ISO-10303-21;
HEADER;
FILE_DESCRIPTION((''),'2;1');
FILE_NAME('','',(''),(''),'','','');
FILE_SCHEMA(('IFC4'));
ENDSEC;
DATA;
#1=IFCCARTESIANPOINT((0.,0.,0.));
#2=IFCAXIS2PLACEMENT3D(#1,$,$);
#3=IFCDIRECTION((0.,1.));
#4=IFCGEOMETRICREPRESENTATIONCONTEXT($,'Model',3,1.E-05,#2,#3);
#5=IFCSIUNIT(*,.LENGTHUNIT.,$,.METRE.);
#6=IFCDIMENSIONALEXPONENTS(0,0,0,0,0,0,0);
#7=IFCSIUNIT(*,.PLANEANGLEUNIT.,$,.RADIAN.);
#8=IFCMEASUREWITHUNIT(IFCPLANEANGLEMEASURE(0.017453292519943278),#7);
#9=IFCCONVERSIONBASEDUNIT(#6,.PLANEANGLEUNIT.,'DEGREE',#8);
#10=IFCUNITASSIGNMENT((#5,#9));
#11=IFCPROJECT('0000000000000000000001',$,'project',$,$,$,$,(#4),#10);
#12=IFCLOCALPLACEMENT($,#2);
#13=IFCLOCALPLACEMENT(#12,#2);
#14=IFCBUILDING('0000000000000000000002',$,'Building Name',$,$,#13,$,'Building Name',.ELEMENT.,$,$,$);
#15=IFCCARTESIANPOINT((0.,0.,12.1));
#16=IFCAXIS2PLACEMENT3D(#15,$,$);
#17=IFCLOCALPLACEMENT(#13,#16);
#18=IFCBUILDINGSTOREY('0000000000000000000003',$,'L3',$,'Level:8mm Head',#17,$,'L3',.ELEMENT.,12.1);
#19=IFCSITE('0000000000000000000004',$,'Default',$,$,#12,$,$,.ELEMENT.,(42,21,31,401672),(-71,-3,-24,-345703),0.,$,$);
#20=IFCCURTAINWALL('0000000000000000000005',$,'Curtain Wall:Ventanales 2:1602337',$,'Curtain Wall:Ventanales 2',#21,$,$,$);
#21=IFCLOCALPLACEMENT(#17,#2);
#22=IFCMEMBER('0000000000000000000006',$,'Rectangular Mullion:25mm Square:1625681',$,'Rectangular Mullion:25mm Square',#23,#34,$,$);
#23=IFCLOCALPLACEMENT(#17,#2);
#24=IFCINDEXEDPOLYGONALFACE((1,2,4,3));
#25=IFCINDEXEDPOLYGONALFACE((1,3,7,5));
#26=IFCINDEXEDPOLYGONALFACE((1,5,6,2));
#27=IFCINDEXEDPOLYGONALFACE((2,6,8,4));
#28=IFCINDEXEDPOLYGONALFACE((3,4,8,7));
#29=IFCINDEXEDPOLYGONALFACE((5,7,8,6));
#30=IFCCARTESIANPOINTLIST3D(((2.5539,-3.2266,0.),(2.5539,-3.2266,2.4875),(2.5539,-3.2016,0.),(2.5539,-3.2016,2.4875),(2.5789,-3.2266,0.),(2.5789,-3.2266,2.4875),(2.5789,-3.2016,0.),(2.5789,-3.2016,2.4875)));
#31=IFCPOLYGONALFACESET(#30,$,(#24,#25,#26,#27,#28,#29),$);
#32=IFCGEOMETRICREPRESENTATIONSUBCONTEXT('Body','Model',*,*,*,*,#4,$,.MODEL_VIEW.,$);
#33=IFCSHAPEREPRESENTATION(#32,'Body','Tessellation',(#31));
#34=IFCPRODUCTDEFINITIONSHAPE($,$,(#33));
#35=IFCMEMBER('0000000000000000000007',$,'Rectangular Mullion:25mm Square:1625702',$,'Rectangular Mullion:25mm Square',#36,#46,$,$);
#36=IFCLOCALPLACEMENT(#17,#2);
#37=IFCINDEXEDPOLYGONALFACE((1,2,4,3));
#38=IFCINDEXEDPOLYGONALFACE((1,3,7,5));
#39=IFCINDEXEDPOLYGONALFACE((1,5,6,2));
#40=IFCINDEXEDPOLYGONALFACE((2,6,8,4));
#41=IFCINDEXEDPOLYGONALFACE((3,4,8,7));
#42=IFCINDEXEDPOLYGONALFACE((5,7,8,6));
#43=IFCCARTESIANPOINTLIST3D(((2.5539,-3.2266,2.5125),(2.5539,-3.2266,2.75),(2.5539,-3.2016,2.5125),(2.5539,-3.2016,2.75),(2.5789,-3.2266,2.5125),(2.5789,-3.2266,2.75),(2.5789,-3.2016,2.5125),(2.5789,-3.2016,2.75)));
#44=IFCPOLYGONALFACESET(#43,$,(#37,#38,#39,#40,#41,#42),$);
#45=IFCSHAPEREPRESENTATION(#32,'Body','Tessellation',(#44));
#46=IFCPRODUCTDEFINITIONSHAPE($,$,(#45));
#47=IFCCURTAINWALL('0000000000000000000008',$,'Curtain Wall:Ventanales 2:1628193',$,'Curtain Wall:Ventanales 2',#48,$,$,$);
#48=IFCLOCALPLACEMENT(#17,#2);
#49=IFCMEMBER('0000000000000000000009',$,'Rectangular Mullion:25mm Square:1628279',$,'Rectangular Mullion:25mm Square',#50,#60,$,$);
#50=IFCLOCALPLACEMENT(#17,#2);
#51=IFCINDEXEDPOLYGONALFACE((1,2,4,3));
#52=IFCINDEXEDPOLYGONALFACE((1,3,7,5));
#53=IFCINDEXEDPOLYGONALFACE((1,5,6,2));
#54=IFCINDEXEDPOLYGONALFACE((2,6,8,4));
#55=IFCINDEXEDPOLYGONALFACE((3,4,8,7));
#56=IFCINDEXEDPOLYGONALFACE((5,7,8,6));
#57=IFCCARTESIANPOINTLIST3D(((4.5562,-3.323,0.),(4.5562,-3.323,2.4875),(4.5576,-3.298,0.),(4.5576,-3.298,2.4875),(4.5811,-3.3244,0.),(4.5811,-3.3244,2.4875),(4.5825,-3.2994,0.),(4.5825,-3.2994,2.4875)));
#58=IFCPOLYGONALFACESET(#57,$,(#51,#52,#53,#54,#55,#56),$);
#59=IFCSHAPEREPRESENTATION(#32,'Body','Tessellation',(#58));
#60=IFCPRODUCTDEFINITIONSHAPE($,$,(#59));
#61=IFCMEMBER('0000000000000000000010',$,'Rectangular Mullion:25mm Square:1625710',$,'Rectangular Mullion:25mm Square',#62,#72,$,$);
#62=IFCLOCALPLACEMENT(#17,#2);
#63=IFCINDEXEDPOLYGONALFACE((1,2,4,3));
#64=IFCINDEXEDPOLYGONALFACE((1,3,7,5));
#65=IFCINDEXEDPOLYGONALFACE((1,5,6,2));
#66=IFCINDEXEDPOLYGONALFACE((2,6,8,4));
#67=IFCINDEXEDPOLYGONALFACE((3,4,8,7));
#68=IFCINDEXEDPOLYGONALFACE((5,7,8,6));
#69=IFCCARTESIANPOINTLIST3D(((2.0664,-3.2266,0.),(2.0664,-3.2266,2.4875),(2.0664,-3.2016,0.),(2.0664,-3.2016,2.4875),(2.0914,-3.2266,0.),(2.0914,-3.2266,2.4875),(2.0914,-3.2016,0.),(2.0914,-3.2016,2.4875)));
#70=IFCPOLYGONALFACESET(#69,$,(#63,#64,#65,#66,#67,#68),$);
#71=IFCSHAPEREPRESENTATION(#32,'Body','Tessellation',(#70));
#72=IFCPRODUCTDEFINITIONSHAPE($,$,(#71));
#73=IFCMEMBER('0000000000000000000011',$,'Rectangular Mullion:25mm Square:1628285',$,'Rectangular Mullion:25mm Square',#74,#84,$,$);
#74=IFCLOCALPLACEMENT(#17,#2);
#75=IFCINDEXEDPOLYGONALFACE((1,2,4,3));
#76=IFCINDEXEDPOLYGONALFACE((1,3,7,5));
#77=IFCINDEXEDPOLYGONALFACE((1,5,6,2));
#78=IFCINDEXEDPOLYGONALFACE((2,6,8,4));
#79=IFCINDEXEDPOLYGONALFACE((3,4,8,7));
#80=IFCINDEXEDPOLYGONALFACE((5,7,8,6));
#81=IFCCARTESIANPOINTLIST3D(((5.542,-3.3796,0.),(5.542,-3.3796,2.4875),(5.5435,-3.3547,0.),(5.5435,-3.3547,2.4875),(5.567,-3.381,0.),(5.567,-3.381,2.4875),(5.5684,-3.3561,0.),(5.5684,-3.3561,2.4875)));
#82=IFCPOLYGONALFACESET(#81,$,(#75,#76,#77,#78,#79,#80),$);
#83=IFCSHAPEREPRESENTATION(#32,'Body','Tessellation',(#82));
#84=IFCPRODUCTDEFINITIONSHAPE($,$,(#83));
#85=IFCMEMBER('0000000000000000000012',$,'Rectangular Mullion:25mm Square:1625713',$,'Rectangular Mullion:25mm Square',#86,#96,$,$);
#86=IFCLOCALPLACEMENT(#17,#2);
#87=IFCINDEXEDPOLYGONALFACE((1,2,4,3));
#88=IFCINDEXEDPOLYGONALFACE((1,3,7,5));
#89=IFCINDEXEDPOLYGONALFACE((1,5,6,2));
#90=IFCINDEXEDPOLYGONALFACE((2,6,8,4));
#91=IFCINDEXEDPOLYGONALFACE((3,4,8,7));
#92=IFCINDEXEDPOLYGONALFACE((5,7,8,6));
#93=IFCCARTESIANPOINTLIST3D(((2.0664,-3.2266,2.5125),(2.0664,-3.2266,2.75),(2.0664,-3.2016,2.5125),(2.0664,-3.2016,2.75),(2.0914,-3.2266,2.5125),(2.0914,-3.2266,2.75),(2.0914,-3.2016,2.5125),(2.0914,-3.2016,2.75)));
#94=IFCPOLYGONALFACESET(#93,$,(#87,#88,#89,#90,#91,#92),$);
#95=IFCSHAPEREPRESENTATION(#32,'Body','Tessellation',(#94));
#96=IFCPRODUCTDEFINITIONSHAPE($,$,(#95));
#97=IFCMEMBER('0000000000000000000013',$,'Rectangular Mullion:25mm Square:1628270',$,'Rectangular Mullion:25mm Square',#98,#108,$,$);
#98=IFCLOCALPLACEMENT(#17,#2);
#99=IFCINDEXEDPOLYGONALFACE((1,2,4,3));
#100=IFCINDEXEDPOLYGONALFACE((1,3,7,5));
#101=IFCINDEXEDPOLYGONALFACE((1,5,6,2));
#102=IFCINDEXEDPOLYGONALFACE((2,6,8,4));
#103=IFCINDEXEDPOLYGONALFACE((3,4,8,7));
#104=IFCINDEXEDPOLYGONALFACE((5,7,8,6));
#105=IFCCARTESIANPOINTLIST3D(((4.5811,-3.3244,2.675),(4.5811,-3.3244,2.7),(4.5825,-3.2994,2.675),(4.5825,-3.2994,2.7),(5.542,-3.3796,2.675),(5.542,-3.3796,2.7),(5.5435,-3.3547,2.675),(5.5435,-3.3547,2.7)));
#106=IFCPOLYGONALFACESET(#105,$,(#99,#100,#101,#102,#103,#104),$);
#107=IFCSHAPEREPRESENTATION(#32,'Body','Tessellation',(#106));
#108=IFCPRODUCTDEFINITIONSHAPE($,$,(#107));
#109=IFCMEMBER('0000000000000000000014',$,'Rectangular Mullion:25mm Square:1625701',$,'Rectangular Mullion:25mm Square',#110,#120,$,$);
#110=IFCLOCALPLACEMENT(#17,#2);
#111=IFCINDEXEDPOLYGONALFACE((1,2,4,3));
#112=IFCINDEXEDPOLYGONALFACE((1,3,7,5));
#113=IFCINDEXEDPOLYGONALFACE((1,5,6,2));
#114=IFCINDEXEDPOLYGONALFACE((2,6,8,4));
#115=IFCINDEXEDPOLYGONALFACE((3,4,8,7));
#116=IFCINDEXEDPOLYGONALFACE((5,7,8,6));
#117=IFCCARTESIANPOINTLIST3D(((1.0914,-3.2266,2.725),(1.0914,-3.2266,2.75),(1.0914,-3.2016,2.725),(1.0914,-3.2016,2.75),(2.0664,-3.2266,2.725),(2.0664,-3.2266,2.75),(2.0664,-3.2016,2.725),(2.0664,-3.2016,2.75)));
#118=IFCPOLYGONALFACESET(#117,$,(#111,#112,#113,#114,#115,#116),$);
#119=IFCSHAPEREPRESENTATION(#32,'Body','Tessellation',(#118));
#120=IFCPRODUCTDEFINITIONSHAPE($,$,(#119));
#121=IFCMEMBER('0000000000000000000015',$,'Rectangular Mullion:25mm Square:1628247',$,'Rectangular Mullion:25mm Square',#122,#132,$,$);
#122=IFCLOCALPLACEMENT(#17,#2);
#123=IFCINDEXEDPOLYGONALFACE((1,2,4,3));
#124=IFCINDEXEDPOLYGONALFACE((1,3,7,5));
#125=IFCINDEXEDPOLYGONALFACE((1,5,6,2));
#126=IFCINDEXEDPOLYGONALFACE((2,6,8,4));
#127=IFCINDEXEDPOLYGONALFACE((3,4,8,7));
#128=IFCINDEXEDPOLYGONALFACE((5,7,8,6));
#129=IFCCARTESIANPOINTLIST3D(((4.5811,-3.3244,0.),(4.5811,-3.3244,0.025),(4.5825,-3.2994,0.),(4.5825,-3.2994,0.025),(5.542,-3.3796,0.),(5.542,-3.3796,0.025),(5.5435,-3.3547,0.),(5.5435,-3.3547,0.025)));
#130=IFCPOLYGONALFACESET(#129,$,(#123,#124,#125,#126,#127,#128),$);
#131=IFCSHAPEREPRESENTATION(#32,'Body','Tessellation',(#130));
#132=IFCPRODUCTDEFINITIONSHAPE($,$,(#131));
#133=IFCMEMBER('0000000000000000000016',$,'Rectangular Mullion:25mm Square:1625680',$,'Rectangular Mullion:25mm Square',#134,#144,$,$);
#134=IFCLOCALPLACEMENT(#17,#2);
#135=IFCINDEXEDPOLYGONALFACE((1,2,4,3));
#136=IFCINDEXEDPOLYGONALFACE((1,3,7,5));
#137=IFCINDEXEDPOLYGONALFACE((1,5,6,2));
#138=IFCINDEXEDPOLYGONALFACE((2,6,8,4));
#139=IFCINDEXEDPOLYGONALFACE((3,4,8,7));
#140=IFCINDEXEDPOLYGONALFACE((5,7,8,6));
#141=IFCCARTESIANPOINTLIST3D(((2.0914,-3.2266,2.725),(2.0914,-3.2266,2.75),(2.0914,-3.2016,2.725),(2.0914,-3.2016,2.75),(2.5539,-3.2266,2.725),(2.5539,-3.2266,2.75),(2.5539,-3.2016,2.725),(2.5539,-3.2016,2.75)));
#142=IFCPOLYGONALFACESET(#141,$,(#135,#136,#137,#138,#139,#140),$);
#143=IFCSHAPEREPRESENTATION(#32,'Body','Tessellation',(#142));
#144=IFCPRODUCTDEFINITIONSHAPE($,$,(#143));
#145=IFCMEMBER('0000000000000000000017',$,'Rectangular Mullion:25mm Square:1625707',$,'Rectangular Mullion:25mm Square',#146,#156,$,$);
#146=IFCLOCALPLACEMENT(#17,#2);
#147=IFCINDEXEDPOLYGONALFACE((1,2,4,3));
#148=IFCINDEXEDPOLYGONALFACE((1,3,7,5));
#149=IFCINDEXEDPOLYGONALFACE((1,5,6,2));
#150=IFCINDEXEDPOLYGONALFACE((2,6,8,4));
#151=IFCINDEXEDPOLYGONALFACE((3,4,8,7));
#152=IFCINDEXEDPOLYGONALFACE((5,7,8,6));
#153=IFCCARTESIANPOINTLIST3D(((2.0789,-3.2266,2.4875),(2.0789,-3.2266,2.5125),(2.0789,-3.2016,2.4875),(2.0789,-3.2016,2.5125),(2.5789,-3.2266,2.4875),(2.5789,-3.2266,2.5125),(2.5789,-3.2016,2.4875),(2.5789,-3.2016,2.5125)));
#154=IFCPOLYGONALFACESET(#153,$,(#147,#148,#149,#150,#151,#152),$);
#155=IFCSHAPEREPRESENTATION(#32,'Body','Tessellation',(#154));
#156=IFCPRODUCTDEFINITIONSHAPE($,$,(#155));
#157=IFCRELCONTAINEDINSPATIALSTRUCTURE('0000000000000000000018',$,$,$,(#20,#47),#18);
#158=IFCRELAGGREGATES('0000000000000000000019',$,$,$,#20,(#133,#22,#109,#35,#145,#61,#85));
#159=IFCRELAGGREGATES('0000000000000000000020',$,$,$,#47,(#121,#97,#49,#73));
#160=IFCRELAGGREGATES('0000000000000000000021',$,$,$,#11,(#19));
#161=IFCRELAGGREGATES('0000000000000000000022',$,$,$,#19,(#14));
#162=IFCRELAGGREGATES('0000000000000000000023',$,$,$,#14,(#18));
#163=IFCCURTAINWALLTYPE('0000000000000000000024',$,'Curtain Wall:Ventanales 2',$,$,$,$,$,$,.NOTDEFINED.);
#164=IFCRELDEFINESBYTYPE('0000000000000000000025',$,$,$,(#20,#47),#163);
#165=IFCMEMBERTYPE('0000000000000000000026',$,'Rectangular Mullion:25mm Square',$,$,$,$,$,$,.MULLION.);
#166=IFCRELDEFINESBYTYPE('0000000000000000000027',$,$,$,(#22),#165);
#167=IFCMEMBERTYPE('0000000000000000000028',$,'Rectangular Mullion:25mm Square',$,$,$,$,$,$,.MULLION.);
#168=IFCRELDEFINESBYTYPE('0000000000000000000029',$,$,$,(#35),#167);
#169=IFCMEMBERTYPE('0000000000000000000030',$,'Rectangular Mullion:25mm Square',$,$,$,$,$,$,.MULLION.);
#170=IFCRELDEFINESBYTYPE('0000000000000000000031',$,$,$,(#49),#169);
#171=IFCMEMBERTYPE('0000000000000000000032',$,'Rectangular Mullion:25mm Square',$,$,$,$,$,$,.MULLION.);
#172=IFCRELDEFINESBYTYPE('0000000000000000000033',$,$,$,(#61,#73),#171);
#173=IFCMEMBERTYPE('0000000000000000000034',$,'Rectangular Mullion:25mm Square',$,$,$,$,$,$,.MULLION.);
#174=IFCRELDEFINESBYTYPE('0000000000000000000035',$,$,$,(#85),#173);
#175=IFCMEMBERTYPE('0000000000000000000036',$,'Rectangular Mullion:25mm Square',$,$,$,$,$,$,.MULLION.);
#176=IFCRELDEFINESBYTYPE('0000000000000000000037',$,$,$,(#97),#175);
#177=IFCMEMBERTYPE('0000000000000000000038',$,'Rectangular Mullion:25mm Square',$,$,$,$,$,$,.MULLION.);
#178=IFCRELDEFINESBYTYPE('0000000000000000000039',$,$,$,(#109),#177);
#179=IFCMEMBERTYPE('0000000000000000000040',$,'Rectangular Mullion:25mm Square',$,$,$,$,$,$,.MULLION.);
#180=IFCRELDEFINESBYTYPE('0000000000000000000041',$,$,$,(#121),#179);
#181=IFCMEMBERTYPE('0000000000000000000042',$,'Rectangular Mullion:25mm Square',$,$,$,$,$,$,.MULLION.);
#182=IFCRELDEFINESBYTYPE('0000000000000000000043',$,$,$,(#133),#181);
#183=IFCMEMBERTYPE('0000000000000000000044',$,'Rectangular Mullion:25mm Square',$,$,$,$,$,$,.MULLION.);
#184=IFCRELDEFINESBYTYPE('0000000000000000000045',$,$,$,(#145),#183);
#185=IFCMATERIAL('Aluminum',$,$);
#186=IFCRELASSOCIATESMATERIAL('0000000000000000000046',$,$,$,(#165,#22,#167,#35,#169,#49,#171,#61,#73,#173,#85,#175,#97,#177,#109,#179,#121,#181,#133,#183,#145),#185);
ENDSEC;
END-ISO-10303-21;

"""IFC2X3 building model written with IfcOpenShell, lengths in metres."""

from ifc_helpers import new_model, entity, si_unit, converted_unit, direction, frame, frame_2d, origin, origin_2d_with_axis, place, context, subcontext, project, spatial, rectangle, extrude, source, transform, mapped, material, type_object, type_shapes, element, aggregate, save


model = new_model("IFC2X3")

# Units and contexts
model_context = context("Model", 3, precision=1e-05, world=origin(), true_north=direction((0.0, 1.0)))
body_context = subcontext(model_context, "Body", "Model", "MODEL_VIEW")
ifc_project = project(units=[si_unit("LENGTHUNIT", "METRE"), converted_unit("PLANEANGLEUNIT", "DEGREE", entity("IfcPlaneAngleMeasure", 0.017453292519943278), si_unit("PLANEANGLEUNIT", "RADIAN"), dimensions=[0, 0, 0, 0, 0, 0, 0])], contexts=[model_context])

# Site, building, storey
site_placement = place(None, origin())
site = spatial("IfcSite", under=ifc_project, at=site_placement, Name="Default", CompositionType="ELEMENT", RefLatitude=(42, 21, 31, 401672), RefLongitude=(-71, -3, -24, -345703), RefElevation=0.0)
building_placement = place(site_placement, origin())
building = spatial("IfcBuilding", under=site, at=building_placement, Name="Building Name", LongName="Building Name", CompositionType="ELEMENT")
storey_placement = place(building_placement, frame((0.0, 0.0, 12.1)))
storey = spatial("IfcBuildingStorey", under=building, at=storey_placement, Name="L3", ObjectType="Level:8mm Head", LongName="L3", CompositionType="ELEMENT", Elevation=12.1)

# Curtain wall, members
curtain_wall_type = type_object("IfcCurtainWallType", Name="Curtain Wall:Ventanales 2", PredefinedType="NOTDEFINED")
curtain_wall_1_placement = place(storey_placement, frame((0.0, 0.0, -12.1)))
curtain_wall_1 = element("IfcCurtainWall", 1, at=curtain_wall_1_placement, inside=storey, type_object=curtain_wall_type, Name="Curtain Wall:Ventanales 2:1602337", ObjectType="Curtain Wall:Ventanales 2")
ifc_material_1 = material(Name="Aluminum")
member_type_1 = type_object("IfcMemberType", Name="Rectangular Mullion:25mm Square", PredefinedType="MULLION", material=ifc_material_1)
shared_shape_1 = source(origin(), body_context, "Body", "SweptSolid", [
    extrude(rectangle(XDim=0.025, YDim=0.025, at=origin_2d_with_axis()), frame((-0.0125, 0.0, -2.4875), z_axis=(0.0, 0.0, 1.0), x_axis=(-1.0, 0.0, 0.0)), (0.0, 0.0, 1.0), 2.4875),
])
type_shapes(member_type_1, [shared_shape_1])
member_1_placement = place(curtain_wall_1_placement, frame((2.5789, -3.2141, 12.1), z_axis=(0.0, 0.0, -1.0), x_axis=(1.0, 0.0, 0.0)))
member_1 = element("IfcMember", 2, at=member_1_placement, type_object=member_type_1, material=ifc_material_1, Name="Rectangular Mullion:25mm Square:1625681", ObjectType="Rectangular Mullion:25mm Square", context=body_context, shape_type="MappedRepresentation", body=[
    mapped(shared_shape_1, transform((0.0, 0.0, 0.0), scale=1.0)),
])
member_type_2 = type_object("IfcMemberType", Name="Rectangular Mullion:25mm Square", PredefinedType="MULLION", material=ifc_material_1)
shared_shape_2 = source(origin(), body_context, "Body", "SweptSolid", [
    extrude(rectangle(XDim=0.025, YDim=0.025, at=origin_2d_with_axis()), frame((-0.0125, 0.0, -0.2375), z_axis=(0.0, 0.0, 1.0), x_axis=(-1.0, 0.0, 0.0)), (0.0, 0.0, 1.0), 0.2375),
])
type_shapes(member_type_2, [shared_shape_2])
member_2_placement = place(curtain_wall_1_placement, frame((2.5789, -3.2141, 14.6125), z_axis=(0.0, 0.0, -1.0), x_axis=(1.0, 0.0, 0.0)))
member_2 = element("IfcMember", 3, at=member_2_placement, type_object=member_type_2, material=ifc_material_1, Name="Rectangular Mullion:25mm Square:1625702", ObjectType="Rectangular Mullion:25mm Square", context=body_context, shape_type="MappedRepresentation", body=[
    mapped(shared_shape_2, transform((0.0, 0.0, 0.0), scale=1.0)),
])

# Curtain wall, member
curtain_wall_2_placement = place(storey_placement, frame((0.0, 0.0, -12.1)))
curtain_wall_2 = element("IfcCurtainWall", 4, at=curtain_wall_2_placement, inside=storey, type_object=curtain_wall_type, Name="Curtain Wall:Ventanales 2:1628193", ObjectType="Curtain Wall:Ventanales 2")
member_type_3 = type_object("IfcMemberType", Name="Rectangular Mullion:25mm Square", PredefinedType="MULLION", material=ifc_material_1)
shared_shape_3 = source(origin(), body_context, "Body", "SweptSolid", [
    extrude(rectangle(XDim=0.025, YDim=0.025, at=origin_2d_with_axis()), frame((-0.0125, 0.0, -2.4875), z_axis=(0.0, 0.0, 1.0), x_axis=(-1.0, 0.0, 0.0)), (0.0, 0.0, 1.0), 2.4875),
])
type_shapes(member_type_3, [shared_shape_3])
member_3_placement = place(curtain_wall_2_placement, frame((4.5569, -3.3105, 14.5875), z_axis=(0.0, 0.0, 1.0), x_axis=(-0.998353, 0.057365, 0.0)))
member_3 = element("IfcMember", 5, at=member_3_placement, type_object=member_type_3, material=ifc_material_1, Name="Rectangular Mullion:25mm Square:1628279", ObjectType="Rectangular Mullion:25mm Square", context=body_context, shape_type="MappedRepresentation", body=[
    mapped(shared_shape_3, transform((0.0, 0.0, 0.0), scale=1.0)),
])

# Members
member_type_4 = type_object("IfcMemberType", Name="Rectangular Mullion:25mm Square", PredefinedType="MULLION", material=ifc_material_1)
shared_shape_4 = source(origin(), body_context, "Body", "SweptSolid", [
    extrude(rectangle(XDim=0.025, YDim=0.025, at=origin_2d_with_axis()), frame((0.0, 0.0, -2.4875), z_axis=(0.0, 0.0, 1.0), x_axis=(-1.0, 0.0, 0.0)), (0.0, 0.0, 1.0), 2.4875),
])
type_shapes(member_type_4, [shared_shape_4])
member_4_placement = place(curtain_wall_1_placement, frame((2.0789, -3.2141, 12.1), z_axis=(0.0, 0.0, -1.0), x_axis=(1.0, 0.0, 0.0)))
member_4 = element("IfcMember", 6, at=member_4_placement, type_object=member_type_4, material=ifc_material_1, Name="Rectangular Mullion:25mm Square:1625710", ObjectType="Rectangular Mullion:25mm Square", context=body_context, shape_type="MappedRepresentation", body=[
    mapped(shared_shape_4, transform((0.0, 0.0, 0.0), scale=1.0)),
])
member_5_placement = place(curtain_wall_2_placement, frame((5.5552, -3.3679, 12.1), z_axis=(0.0, 0.0, -1.0), x_axis=(0.998353, -0.057365, 0.0)))
member_5 = element("IfcMember", 7, at=member_5_placement, type_object=member_type_4, material=ifc_material_1, Name="Rectangular Mullion:25mm Square:1628285", ObjectType="Rectangular Mullion:25mm Square", context=body_context, shape_type="MappedRepresentation", body=[
    mapped(shared_shape_4, transform((0.0, 0.0, 0.0), scale=1.0)),
])
member_type_5 = type_object("IfcMemberType", Name="Rectangular Mullion:25mm Square", PredefinedType="MULLION", material=ifc_material_1)
shared_shape_5 = source(origin(), body_context, "Body", "SweptSolid", [
    extrude(rectangle(XDim=0.025, YDim=0.025, at=frame_2d((0.0, 0.0), x_axis=(1.0, 0.0))), frame((0.0, 0.0, -0.2375), z_axis=(0.0, 0.0, 1.0), x_axis=(-1.0, 0.0, 0.0)), (0.0, 0.0, 1.0), 0.2375),
])
type_shapes(member_type_5, [shared_shape_5])
member_6_placement = place(curtain_wall_1_placement, frame((2.0789, -3.2141, 14.6125), z_axis=(0.0, 0.0, -1.0), x_axis=(1.0, 0.0, 0.0)))
member_6 = element("IfcMember", 8, at=member_6_placement, type_object=member_type_5, material=ifc_material_1, Name="Rectangular Mullion:25mm Square:1625713", ObjectType="Rectangular Mullion:25mm Square", context=body_context, shape_type="MappedRepresentation", body=[
    mapped(shared_shape_5, transform((0.0, 0.0, 0.0), scale=1.0)),
])
member_type_6 = type_object("IfcMemberType", Name="Rectangular Mullion:25mm Square", PredefinedType="MULLION", material=ifc_material_1)
shared_shape_6 = source(origin(), body_context, "Body", "SweptSolid", [
    extrude(rectangle(XDim=0.025, YDim=0.025, at=origin_2d_with_axis()), frame((-0.0125, 0.0, -0.9625), z_axis=(0.0, 0.0, 1.0), x_axis=(-1.0, 0.0, 0.0)), (0.0, 0.0, 1.0), 0.9625),
])
type_shapes(member_type_6, [shared_shape_6])
member_7_placement = place(curtain_wall_2_placement, frame((5.5427, -3.3671, 14.8), z_axis=(0.998353, -0.057365, 0.0), x_axis=(0.0, 0.0, 1.0)))
member_7 = element("IfcMember", 9, at=member_7_placement, type_object=member_type_6, material=ifc_material_1, Name="Rectangular Mullion:25mm Square:1628270", ObjectType="Rectangular Mullion:25mm Square", context=body_context, shape_type="MappedRepresentation", body=[
    mapped(shared_shape_6, transform((0.0, 0.0, 0.0), scale=1.0)),
])
member_type_7 = type_object("IfcMemberType", Name="Rectangular Mullion:25mm Square", PredefinedType="MULLION", material=ifc_material_1)
shared_shape_7 = source(origin(), body_context, "Body", "SweptSolid", [
    extrude(rectangle(XDim=0.025, YDim=0.025, at=origin_2d_with_axis()), frame((-0.0125, 0.0, -0.975), z_axis=(0.0, 0.0, 1.0), x_axis=(-1.0, 0.0, 0.0)), (0.0, 0.0, 1.0), 0.975),
])
type_shapes(member_type_7, [shared_shape_7])
member_8_placement = place(curtain_wall_1_placement, frame((2.0664, -3.2141, 14.85), z_axis=(1.0, 0.0, 0.0), x_axis=(0.0, 0.0, 1.0)))
member_8 = element("IfcMember", 10, at=member_8_placement, type_object=member_type_7, material=ifc_material_1, Name="Rectangular Mullion:25mm Square:1625701", ObjectType="Rectangular Mullion:25mm Square", context=body_context, shape_type="MappedRepresentation", body=[
    mapped(shared_shape_7, transform((0.0, 0.0, 0.0), scale=1.0)),
])
member_type_8 = type_object("IfcMemberType", Name="Rectangular Mullion:25mm Square", PredefinedType="MULLION", material=ifc_material_1)
shared_shape_8 = source(origin(), body_context, "Body", "SweptSolid", [
    extrude(rectangle(XDim=0.025, YDim=0.025, at=origin_2d_with_axis()), frame((-0.0125, 0.0, -0.9625), z_axis=(0.0, 0.0, 1.0), x_axis=(-1.0, 0.0, 0.0)), (0.0, 0.0, 1.0), 0.9625),
])
type_shapes(member_type_8, [shared_shape_8])
member_9_placement = place(curtain_wall_2_placement, frame((4.5818, -3.3119, 12.1), z_axis=(-0.998353, 0.057365, 0.0), x_axis=(0.0, 0.0, -1.0)))
member_9 = element("IfcMember", 11, at=member_9_placement, type_object=member_type_8, material=ifc_material_1, Name="Rectangular Mullion:25mm Square:1628247", ObjectType="Rectangular Mullion:25mm Square", context=body_context, shape_type="MappedRepresentation", body=[
    mapped(shared_shape_8, transform((0.0, 0.0, 0.0), scale=1.0)),
])
member_type_9 = type_object("IfcMemberType", Name="Rectangular Mullion:25mm Square", PredefinedType="MULLION", material=ifc_material_1)
shared_shape_9 = source(origin(), body_context, "Body", "SweptSolid", [
    extrude(rectangle(XDim=0.025, YDim=0.025, at=origin_2d_with_axis()), frame((-0.0125, 0.0, -0.4625), z_axis=(0.0, 0.0, 1.0), x_axis=(-1.0, 0.0, 0.0)), (0.0, 0.0, 1.0), 0.4625),
])
type_shapes(member_type_9, [shared_shape_9])
member_10_placement = place(curtain_wall_1_placement, frame((2.5539, -3.2141, 14.85), z_axis=(1.0, 0.0, 0.0), x_axis=(0.0, 0.0, 1.0)))
member_10 = element("IfcMember", 12, at=member_10_placement, type_object=member_type_9, material=ifc_material_1, Name="Rectangular Mullion:25mm Square:1625680", ObjectType="Rectangular Mullion:25mm Square", context=body_context, shape_type="MappedRepresentation", body=[
    mapped(shared_shape_9, transform((0.0, 0.0, 0.0), scale=1.0)),
])
member_type_10 = type_object("IfcMemberType", Name="Rectangular Mullion:25mm Square", PredefinedType="MULLION", material=ifc_material_1)
shared_shape_10 = source(origin(), body_context, "Body", "SweptSolid", [
    extrude(rectangle(XDim=0.025, YDim=0.025, at=frame_2d((0.0, 0.0), x_axis=(1.0, 0.0))), frame((0.0, 0.0, -0.5), z_axis=(0.0, 0.0, 1.0), x_axis=(-1.0, 0.0, 0.0)), (0.0, 0.0, 1.0), 0.5),
])
type_shapes(member_type_10, [shared_shape_10])
member_11_placement = place(curtain_wall_1_placement, frame((2.5789, -3.2141, 14.6), z_axis=(1.0, 0.0, 0.0), x_axis=(0.0, 0.0, 1.0)))
member_11 = element("IfcMember", 13, at=member_11_placement, type_object=member_type_10, material=ifc_material_1, Name="Rectangular Mullion:25mm Square:1625707", ObjectType="Rectangular Mullion:25mm Square", context=body_context, shape_type="MappedRepresentation", body=[
    mapped(shared_shape_10, transform((0.0, 0.0, 0.0), scale=1.0)),
])

aggregate(curtain_wall_1, [member_10, member_1, member_8, member_2, member_11, member_4, member_6])
aggregate(curtain_wall_2, [member_9, member_7, member_3, member_5])

save(model, "model.ifc")
